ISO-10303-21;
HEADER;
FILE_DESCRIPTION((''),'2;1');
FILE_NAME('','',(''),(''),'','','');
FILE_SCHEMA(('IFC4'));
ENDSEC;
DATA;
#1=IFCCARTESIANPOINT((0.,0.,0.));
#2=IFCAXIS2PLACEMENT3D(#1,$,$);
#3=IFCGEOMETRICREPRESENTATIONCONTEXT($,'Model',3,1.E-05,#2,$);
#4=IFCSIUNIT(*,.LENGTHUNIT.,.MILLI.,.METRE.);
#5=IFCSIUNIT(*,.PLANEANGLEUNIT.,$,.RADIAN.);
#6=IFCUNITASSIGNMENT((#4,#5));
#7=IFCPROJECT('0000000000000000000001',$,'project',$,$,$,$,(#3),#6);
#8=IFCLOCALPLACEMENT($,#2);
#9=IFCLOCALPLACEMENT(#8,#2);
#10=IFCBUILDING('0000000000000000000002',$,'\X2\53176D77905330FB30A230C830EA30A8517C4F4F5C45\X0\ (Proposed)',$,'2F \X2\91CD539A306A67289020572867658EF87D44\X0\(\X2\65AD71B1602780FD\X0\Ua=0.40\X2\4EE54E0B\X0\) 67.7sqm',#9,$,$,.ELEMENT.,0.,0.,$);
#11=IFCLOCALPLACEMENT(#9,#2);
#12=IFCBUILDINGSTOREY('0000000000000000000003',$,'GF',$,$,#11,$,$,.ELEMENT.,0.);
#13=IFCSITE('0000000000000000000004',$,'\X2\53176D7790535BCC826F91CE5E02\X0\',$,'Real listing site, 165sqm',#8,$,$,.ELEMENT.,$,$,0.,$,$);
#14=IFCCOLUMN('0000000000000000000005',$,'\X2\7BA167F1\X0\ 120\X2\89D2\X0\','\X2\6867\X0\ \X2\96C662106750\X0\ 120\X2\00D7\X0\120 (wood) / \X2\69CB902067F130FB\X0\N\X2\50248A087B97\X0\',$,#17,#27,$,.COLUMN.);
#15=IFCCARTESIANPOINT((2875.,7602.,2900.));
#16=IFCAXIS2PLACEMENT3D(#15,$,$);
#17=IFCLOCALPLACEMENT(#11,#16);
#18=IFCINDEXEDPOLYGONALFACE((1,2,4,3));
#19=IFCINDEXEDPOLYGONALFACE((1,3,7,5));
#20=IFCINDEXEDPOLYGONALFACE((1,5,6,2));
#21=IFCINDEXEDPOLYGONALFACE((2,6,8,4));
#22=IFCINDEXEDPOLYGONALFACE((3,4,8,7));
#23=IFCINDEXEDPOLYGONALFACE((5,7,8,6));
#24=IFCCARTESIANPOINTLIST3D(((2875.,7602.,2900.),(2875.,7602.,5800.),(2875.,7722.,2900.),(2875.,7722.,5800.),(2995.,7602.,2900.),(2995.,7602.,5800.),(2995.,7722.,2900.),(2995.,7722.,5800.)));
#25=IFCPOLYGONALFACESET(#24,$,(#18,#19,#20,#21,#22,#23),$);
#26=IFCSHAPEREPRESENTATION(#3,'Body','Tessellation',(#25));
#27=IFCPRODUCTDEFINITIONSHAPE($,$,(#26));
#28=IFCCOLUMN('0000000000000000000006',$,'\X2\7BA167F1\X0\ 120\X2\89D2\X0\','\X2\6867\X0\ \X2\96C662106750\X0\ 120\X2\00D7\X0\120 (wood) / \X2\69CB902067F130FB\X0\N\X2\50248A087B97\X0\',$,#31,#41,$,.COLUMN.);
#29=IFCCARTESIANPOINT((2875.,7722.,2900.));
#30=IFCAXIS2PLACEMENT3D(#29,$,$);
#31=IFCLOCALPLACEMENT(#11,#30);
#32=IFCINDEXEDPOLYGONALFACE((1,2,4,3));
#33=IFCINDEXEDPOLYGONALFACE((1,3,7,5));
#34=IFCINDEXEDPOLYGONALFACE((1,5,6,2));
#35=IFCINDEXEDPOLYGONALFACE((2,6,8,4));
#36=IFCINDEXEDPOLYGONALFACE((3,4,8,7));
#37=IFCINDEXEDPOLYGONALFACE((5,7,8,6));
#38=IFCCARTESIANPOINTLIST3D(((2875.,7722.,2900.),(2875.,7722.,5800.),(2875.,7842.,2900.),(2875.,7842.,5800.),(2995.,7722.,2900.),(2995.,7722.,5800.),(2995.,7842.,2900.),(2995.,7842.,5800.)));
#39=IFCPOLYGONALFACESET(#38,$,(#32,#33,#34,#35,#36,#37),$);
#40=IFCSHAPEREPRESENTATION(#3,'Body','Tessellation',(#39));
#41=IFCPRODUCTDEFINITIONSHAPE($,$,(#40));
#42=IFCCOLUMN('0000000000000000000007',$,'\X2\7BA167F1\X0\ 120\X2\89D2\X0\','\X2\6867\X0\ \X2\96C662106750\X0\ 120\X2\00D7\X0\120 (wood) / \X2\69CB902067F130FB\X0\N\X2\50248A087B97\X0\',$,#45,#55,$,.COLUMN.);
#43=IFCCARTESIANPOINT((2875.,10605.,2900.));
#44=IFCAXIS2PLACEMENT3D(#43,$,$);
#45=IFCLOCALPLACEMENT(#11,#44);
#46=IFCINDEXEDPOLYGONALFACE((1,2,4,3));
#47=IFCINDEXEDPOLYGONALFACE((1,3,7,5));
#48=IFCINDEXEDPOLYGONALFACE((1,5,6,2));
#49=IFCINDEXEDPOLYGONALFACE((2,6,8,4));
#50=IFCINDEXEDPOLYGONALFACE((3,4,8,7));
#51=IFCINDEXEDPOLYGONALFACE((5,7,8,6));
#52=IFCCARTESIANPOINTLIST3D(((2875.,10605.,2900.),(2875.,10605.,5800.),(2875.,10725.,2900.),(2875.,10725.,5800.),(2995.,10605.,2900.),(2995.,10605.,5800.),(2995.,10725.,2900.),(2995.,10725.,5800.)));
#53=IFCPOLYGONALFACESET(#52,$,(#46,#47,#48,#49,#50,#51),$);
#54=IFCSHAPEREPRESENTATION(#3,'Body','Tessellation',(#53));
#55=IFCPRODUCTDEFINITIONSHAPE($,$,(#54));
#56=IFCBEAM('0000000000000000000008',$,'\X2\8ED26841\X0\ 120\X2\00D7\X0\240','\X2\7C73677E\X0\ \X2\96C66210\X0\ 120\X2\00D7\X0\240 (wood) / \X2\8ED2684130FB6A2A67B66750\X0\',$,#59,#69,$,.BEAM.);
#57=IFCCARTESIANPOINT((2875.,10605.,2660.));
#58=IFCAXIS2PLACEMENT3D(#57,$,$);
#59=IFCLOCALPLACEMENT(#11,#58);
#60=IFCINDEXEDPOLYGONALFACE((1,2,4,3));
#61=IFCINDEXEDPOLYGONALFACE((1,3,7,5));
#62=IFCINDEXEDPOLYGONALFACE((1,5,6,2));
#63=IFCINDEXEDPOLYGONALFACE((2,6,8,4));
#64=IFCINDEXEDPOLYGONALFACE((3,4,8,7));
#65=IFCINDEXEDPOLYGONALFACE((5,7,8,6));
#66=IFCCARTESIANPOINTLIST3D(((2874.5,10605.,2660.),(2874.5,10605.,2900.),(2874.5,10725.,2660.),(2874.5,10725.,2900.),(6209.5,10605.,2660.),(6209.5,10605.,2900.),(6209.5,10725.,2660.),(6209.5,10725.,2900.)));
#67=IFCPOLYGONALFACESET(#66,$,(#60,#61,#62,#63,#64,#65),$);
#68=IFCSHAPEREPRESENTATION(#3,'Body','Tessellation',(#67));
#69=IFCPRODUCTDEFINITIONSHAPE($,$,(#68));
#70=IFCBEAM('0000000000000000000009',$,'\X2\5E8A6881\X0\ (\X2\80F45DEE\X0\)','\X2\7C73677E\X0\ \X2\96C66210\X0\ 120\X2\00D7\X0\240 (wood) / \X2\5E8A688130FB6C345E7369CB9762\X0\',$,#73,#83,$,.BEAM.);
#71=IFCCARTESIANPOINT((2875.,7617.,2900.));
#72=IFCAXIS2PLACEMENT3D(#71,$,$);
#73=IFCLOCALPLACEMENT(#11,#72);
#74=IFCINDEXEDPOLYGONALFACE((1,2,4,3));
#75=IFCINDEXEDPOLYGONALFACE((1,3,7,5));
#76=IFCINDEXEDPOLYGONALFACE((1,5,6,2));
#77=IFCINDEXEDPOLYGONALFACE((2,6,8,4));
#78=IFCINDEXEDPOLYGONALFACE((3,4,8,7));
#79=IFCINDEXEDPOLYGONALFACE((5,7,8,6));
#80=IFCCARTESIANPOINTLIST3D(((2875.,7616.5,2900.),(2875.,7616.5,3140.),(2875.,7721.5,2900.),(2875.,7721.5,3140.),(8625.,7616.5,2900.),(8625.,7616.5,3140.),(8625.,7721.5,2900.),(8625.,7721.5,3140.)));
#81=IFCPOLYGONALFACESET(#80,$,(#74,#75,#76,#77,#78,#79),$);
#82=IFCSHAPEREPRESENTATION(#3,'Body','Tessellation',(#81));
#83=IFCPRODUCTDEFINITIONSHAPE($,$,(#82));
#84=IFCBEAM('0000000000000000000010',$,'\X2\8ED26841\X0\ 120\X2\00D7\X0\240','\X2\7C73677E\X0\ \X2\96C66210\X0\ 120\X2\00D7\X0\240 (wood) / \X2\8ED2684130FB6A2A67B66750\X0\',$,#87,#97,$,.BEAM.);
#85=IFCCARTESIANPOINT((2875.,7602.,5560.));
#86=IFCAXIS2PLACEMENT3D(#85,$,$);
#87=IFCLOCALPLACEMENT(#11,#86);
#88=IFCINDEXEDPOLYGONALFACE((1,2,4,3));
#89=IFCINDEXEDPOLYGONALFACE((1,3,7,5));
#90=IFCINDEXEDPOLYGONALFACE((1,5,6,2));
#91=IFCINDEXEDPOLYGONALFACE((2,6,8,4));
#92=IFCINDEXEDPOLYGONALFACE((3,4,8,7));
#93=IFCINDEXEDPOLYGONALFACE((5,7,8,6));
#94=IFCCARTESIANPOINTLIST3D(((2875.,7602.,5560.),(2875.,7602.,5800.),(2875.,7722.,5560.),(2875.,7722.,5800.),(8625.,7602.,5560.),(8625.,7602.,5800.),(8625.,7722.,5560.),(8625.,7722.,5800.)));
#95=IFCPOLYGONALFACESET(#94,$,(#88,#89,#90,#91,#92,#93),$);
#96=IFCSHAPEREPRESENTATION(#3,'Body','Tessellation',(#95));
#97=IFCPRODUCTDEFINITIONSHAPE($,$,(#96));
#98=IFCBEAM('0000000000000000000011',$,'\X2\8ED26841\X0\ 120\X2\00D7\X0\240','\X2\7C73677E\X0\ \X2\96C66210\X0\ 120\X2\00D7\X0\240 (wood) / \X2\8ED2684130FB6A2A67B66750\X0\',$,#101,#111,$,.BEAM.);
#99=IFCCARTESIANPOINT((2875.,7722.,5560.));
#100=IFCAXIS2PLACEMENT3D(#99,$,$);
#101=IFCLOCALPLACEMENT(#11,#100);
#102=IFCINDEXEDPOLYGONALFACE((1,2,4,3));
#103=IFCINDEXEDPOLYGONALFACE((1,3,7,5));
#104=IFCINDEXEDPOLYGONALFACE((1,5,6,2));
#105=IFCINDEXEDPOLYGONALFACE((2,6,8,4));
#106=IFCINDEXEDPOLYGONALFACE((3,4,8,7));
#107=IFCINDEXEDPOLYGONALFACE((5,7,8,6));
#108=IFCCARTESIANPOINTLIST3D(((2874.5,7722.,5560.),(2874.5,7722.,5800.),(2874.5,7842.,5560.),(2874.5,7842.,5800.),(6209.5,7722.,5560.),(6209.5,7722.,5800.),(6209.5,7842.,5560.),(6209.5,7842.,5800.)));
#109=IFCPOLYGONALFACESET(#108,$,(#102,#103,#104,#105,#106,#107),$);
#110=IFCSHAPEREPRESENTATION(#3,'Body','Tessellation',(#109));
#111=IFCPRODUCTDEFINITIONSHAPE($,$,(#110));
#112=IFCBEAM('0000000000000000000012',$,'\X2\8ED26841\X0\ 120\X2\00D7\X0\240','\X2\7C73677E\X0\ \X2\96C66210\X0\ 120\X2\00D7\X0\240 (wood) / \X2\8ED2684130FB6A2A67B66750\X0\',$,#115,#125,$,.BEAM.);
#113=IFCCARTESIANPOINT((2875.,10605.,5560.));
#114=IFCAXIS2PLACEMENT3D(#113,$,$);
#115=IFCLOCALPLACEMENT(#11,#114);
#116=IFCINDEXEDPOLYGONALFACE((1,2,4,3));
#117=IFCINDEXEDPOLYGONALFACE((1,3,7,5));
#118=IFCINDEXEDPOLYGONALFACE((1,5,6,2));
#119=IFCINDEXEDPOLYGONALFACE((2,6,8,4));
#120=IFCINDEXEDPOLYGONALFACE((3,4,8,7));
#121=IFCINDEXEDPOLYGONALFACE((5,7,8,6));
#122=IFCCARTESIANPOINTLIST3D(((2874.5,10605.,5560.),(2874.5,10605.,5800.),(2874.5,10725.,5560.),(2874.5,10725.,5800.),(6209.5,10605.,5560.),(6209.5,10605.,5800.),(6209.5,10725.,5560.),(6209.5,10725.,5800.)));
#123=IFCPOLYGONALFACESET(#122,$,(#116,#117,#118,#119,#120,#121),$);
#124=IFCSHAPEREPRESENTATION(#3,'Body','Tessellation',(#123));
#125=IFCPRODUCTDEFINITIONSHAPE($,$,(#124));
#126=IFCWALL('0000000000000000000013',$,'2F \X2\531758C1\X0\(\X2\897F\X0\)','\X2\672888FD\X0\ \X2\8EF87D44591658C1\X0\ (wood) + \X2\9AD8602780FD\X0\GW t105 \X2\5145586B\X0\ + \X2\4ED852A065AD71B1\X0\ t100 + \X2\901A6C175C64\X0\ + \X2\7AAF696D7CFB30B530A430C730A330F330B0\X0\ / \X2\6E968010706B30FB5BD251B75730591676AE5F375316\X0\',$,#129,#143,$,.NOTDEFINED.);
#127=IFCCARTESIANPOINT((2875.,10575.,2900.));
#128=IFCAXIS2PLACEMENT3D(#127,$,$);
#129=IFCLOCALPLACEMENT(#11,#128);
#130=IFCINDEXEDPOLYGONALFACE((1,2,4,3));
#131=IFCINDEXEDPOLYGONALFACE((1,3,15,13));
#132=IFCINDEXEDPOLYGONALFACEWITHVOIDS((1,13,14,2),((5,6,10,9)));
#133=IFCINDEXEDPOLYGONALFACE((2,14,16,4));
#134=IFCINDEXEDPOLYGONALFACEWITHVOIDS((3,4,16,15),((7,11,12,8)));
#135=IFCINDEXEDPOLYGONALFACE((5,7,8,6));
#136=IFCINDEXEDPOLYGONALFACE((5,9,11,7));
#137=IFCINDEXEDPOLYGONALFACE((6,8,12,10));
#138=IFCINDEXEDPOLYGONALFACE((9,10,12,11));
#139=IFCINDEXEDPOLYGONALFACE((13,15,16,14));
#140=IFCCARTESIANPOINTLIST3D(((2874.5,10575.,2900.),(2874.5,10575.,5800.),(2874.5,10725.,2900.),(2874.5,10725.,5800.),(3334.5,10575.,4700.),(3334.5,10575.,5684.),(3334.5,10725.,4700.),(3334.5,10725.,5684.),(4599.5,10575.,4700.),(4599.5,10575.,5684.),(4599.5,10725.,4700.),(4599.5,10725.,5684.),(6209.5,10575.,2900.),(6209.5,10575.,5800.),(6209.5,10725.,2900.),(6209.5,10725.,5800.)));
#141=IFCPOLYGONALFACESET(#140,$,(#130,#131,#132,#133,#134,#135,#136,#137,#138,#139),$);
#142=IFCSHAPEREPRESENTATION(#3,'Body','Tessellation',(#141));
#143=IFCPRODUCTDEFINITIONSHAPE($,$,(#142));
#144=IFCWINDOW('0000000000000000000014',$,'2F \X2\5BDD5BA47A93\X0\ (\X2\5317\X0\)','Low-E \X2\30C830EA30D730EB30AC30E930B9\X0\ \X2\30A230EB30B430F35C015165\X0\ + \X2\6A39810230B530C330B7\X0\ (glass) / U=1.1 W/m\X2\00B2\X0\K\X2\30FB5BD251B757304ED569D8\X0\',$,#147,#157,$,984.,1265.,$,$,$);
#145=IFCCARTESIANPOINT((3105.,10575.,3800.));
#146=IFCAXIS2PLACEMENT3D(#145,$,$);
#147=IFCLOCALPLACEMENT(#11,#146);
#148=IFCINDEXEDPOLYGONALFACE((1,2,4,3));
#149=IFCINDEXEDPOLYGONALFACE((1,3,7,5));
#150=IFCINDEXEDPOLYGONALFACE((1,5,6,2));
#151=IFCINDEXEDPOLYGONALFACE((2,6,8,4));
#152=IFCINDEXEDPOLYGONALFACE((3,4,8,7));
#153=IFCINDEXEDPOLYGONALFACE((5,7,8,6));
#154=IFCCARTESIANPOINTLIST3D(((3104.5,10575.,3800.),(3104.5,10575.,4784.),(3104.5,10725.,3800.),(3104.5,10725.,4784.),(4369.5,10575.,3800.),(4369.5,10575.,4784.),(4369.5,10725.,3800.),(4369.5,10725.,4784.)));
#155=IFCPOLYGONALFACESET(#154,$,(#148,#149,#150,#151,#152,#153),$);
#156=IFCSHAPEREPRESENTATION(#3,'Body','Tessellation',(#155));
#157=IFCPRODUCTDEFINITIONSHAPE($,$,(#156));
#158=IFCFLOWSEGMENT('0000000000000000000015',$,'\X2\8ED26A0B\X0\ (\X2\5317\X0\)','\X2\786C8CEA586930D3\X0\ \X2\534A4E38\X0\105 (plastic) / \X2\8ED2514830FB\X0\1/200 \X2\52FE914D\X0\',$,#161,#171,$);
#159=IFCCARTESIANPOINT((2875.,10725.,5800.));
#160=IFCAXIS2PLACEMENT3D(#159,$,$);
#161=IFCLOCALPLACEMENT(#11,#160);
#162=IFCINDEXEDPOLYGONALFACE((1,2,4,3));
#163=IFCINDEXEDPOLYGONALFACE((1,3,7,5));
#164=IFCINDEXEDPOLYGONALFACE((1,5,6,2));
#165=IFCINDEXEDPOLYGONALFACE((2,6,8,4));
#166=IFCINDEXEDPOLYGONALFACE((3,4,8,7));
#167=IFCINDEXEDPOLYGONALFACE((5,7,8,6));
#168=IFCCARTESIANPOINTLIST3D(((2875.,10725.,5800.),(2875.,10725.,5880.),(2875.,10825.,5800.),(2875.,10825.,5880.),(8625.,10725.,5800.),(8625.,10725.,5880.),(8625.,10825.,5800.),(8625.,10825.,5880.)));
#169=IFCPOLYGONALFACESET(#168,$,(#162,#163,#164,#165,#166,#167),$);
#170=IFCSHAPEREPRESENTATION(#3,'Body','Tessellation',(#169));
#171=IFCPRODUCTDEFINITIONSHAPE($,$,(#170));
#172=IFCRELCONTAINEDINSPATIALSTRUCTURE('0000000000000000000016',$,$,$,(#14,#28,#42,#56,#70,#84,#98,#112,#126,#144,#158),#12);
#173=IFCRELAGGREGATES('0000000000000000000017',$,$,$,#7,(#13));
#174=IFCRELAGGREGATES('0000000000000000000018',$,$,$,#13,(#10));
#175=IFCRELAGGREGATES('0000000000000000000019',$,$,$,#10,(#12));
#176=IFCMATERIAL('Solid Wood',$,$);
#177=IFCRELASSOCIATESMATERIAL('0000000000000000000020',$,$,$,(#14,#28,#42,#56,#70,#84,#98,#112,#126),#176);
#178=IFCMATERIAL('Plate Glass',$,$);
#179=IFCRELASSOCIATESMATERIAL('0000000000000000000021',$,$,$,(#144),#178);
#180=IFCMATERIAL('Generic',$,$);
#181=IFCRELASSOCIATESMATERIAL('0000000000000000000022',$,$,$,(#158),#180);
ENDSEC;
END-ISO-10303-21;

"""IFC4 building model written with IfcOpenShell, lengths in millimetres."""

from ifc_helpers import new_model, si_unit, frame, frame_2d, origin, place, context, project, spatial, rectangle, extrude, material, element, fill, save


model = new_model("IFC4")

# Units and contexts
model_context = context("Model", 3, precision=1e-05, world=origin())
ifc_project = project(units=[si_unit("LENGTHUNIT", "METRE", prefix="MILLI"), si_unit("PLANEANGLEUNIT", "RADIAN")], contexts=[model_context])

# Site, building, storey
site_placement = place(None, origin())
site = spatial("IfcSite", under=ifc_project, at=site_placement, Name="北海道富良野市", ObjectType="Real listing site, 165sqm", CompositionType="ELEMENT", RefElevation=0.0)
building_placement = place(site_placement, origin())
building = spatial("IfcBuilding", under=site, at=building_placement, Name="北海道・アトリエ兼住居 (Proposed)", ObjectType="2F 重厚な木造在来軸組(断熱性能Ua=0.40以下) 67.7sqm", CompositionType="ELEMENT", ElevationOfRefHeight=0.0, ElevationOfTerrain=0.0)
storey_placement = place(building_placement, origin())
storey = spatial("IfcBuildingStorey", under=building, at=storey_placement, Name="GF", CompositionType="ELEMENT", Elevation=0.0)

# Columns
ifc_material_1 = material(Name="Solid Wood")
column_1_placement = place(storey_placement, frame((2875.0, 7602.0, 2900.0)))
element("IfcColumn", 1, at=column_1_placement, inside=storey, material=ifc_material_1, Name="管柱 120角", Description="桧 集成材 120×120 (wood) / 構造柱・N値計算", PredefinedType="COLUMN", context=model_context, shape_type="SweptSolid", body=[
    extrude(rectangle(XDim=120.0, YDim=120.0, at=frame_2d((60.0, 60.0))), frame((2875.0, 7602.0, 2900.0)), (0.0, 0.0, 1.0), 2900.0),
])
column_2_placement = place(storey_placement, frame((2875.0, 7722.0, 2900.0)))
element("IfcColumn", 2, at=column_2_placement, inside=storey, material=ifc_material_1, Name="管柱 120角", Description="桧 集成材 120×120 (wood) / 構造柱・N値計算", PredefinedType="COLUMN", context=model_context, shape_type="SweptSolid", body=[
    extrude(rectangle(XDim=120.0, YDim=120.0, at=frame_2d((60.0, 60.0))), frame((2875.0, 7722.0, 2900.0)), (0.0, 0.0, 1.0), 2900.0),
])
column_3_placement = place(storey_placement, frame((2875.0, 10605.0, 2900.0)))
element("IfcColumn", 3, at=column_3_placement, inside=storey, material=ifc_material_1, Name="管柱 120角", Description="桧 集成材 120×120 (wood) / 構造柱・N値計算", PredefinedType="COLUMN", context=model_context, shape_type="SweptSolid", body=[
    extrude(rectangle(XDim=120.0, YDim=120.0, at=frame_2d((60.0, 60.0))), frame((2875.0, 10605.0, 2900.0)), (0.0, 0.0, 1.0), 2900.0),
])

# Beams
beam_1_placement = place(storey_placement, frame((2875.0, 10605.0, 2660.0)))
element("IfcBeam", 4, at=beam_1_placement, inside=storey, material=ifc_material_1, Name="軒桁 120×240", Description="米松 集成 120×240 (wood) / 軒桁・横架材", PredefinedType="BEAM", context=model_context, shape_type="SweptSolid", body=[
    extrude(rectangle(XDim=3335.0, YDim=120.0, at=frame_2d((1667.0, 60.0))), frame((2875.0, 10605.0, 2660.0)), (0.0, 0.0, 1.0), 240.0),
])
beam_2_placement = place(storey_placement, frame((2875.0, 7617.0, 2900.0)))
element("IfcBeam", 5, at=beam_2_placement, inside=storey, material=ifc_material_1, Name="床梁 (胴差)", Description="米松 集成 120×240 (wood) / 床梁・水平構面", PredefinedType="BEAM", context=model_context, shape_type="SweptSolid", body=[
    extrude(rectangle(XDim=5750.0, YDim=105.0, at=frame_2d((2875.0, 52.0))), frame((2875.0, 7617.0, 2900.0)), (0.0, 0.0, 1.0), 240.0),
])
beam_3_placement = place(storey_placement, frame((2875.0, 7602.0, 5560.0)))
element("IfcBeam", 6, at=beam_3_placement, inside=storey, material=ifc_material_1, Name="軒桁 120×240", Description="米松 集成 120×240 (wood) / 軒桁・横架材", PredefinedType="BEAM", context=model_context, shape_type="SweptSolid", body=[
    extrude(rectangle(XDim=5750.0, YDim=120.0, at=frame_2d((2875.0, 60.0))), frame((2875.0, 7602.0, 5560.0)), (0.0, 0.0, 1.0), 240.0),
])
beam_4_placement = place(storey_placement, frame((2875.0, 7722.0, 5560.0)))
element("IfcBeam", 7, at=beam_4_placement, inside=storey, material=ifc_material_1, Name="軒桁 120×240", Description="米松 集成 120×240 (wood) / 軒桁・横架材", PredefinedType="BEAM", context=model_context, shape_type="SweptSolid", body=[
    extrude(rectangle(XDim=3335.0, YDim=120.0, at=frame_2d((1667.0, 60.0))), frame((2875.0, 7722.0, 5560.0)), (0.0, 0.0, 1.0), 240.0),
])
beam_5_placement = place(storey_placement, frame((2875.0, 10605.0, 5560.0)))
element("IfcBeam", 8, at=beam_5_placement, inside=storey, material=ifc_material_1, Name="軒桁 120×240", Description="米松 集成 120×240 (wood) / 軒桁・横架材", PredefinedType="BEAM", context=model_context, shape_type="SweptSolid", body=[
    extrude(rectangle(XDim=3335.0, YDim=120.0, at=frame_2d((1667.0, 60.0))), frame((2875.0, 10605.0, 5560.0)), (0.0, 0.0, 1.0), 240.0),
])

# Wall, opening, window
wall_1_placement = place(storey_placement, frame((2875.0, 10575.0, 2900.0)))
wall_1 = element("IfcWall", 9, at=wall_1_placement, inside=storey, material=ifc_material_1, Name="2F 北壁(西)", Description="木製 軸組外壁 (wood) + 高性能GW t105 充填 + 付加断熱 t100 + 通気層 + 窯業系サイディング / 準耐火・寒冷地外皮強化", PredefinedType="NOTDEFINED", context=model_context, shape_type="SweptSolid", body=[
    extrude(rectangle(XDim=3335.0, YDim=150.0, at=frame_2d((1667.0, 75.0))), frame((2875.0, 10575.0, 2900.0)), (0.0, 0.0, 1.0), 2900.0),
])
opening_placement = place(storey_placement, frame((3105.0, 10575.0, 3800.0)))
opening = element("IfcOpeningElement", 10, at=opening_placement, cuts=wall_1, PredefinedType="NOTDEFINED", context=model_context, shape_type="SweptSolid", body=[
    extrude(rectangle(XDim=1265.0, YDim=150.0, at=frame_2d((632.0, 75.0))), frame((3105.0, 10575.0, 3800.0)), (0.0, 0.0, 1.0), 984.0),
])
ifc_material_2 = material(Name="Plate Glass")
window_placement = place(storey_placement, frame((3105.0, 10575.0, 3800.0)))
window = element("IfcWindow", 11, at=window_placement, inside=storey, material=ifc_material_2, Name="2F 寝室窓 (北)", Description="Low-E トリプルガラス アルゴン封入 + 樹脂サッシ (glass) / U=1.1 W/m²K・寒冷地仕様", OverallHeight=984.0, OverallWidth=1265.0, context=model_context, shape_type="SweptSolid", body=[
    extrude(rectangle(XDim=1265.0, YDim=150.0, at=frame_2d((632.0, 75.0))), frame((3105.0, 10575.0, 3800.0)), (0.0, 0.0, 1.0), 984.0),
])
fill(opening, window)

# Shared definitions
ifc_material_3 = material(Name="Generic")

# Flow segment
flow_segment_placement = place(storey_placement, frame((2875.0, 10725.0, 5800.0)))
element("IfcFlowSegment", 12, at=flow_segment_placement, inside=storey, material=ifc_material_3, Name="軒樋 (北)", Description="硬質塩ビ 半丸105 (plastic) / 軒先・1/200 勾配", context=model_context, shape_type="SweptSolid", body=[
    extrude(rectangle(XDim=5750.0, YDim=100.0, at=frame_2d((2875.0, 50.0))), frame((2875.0, 10725.0, 5800.0)), (0.0, 0.0, 1.0), 80.0),
])

save(model, "model.ifc")
